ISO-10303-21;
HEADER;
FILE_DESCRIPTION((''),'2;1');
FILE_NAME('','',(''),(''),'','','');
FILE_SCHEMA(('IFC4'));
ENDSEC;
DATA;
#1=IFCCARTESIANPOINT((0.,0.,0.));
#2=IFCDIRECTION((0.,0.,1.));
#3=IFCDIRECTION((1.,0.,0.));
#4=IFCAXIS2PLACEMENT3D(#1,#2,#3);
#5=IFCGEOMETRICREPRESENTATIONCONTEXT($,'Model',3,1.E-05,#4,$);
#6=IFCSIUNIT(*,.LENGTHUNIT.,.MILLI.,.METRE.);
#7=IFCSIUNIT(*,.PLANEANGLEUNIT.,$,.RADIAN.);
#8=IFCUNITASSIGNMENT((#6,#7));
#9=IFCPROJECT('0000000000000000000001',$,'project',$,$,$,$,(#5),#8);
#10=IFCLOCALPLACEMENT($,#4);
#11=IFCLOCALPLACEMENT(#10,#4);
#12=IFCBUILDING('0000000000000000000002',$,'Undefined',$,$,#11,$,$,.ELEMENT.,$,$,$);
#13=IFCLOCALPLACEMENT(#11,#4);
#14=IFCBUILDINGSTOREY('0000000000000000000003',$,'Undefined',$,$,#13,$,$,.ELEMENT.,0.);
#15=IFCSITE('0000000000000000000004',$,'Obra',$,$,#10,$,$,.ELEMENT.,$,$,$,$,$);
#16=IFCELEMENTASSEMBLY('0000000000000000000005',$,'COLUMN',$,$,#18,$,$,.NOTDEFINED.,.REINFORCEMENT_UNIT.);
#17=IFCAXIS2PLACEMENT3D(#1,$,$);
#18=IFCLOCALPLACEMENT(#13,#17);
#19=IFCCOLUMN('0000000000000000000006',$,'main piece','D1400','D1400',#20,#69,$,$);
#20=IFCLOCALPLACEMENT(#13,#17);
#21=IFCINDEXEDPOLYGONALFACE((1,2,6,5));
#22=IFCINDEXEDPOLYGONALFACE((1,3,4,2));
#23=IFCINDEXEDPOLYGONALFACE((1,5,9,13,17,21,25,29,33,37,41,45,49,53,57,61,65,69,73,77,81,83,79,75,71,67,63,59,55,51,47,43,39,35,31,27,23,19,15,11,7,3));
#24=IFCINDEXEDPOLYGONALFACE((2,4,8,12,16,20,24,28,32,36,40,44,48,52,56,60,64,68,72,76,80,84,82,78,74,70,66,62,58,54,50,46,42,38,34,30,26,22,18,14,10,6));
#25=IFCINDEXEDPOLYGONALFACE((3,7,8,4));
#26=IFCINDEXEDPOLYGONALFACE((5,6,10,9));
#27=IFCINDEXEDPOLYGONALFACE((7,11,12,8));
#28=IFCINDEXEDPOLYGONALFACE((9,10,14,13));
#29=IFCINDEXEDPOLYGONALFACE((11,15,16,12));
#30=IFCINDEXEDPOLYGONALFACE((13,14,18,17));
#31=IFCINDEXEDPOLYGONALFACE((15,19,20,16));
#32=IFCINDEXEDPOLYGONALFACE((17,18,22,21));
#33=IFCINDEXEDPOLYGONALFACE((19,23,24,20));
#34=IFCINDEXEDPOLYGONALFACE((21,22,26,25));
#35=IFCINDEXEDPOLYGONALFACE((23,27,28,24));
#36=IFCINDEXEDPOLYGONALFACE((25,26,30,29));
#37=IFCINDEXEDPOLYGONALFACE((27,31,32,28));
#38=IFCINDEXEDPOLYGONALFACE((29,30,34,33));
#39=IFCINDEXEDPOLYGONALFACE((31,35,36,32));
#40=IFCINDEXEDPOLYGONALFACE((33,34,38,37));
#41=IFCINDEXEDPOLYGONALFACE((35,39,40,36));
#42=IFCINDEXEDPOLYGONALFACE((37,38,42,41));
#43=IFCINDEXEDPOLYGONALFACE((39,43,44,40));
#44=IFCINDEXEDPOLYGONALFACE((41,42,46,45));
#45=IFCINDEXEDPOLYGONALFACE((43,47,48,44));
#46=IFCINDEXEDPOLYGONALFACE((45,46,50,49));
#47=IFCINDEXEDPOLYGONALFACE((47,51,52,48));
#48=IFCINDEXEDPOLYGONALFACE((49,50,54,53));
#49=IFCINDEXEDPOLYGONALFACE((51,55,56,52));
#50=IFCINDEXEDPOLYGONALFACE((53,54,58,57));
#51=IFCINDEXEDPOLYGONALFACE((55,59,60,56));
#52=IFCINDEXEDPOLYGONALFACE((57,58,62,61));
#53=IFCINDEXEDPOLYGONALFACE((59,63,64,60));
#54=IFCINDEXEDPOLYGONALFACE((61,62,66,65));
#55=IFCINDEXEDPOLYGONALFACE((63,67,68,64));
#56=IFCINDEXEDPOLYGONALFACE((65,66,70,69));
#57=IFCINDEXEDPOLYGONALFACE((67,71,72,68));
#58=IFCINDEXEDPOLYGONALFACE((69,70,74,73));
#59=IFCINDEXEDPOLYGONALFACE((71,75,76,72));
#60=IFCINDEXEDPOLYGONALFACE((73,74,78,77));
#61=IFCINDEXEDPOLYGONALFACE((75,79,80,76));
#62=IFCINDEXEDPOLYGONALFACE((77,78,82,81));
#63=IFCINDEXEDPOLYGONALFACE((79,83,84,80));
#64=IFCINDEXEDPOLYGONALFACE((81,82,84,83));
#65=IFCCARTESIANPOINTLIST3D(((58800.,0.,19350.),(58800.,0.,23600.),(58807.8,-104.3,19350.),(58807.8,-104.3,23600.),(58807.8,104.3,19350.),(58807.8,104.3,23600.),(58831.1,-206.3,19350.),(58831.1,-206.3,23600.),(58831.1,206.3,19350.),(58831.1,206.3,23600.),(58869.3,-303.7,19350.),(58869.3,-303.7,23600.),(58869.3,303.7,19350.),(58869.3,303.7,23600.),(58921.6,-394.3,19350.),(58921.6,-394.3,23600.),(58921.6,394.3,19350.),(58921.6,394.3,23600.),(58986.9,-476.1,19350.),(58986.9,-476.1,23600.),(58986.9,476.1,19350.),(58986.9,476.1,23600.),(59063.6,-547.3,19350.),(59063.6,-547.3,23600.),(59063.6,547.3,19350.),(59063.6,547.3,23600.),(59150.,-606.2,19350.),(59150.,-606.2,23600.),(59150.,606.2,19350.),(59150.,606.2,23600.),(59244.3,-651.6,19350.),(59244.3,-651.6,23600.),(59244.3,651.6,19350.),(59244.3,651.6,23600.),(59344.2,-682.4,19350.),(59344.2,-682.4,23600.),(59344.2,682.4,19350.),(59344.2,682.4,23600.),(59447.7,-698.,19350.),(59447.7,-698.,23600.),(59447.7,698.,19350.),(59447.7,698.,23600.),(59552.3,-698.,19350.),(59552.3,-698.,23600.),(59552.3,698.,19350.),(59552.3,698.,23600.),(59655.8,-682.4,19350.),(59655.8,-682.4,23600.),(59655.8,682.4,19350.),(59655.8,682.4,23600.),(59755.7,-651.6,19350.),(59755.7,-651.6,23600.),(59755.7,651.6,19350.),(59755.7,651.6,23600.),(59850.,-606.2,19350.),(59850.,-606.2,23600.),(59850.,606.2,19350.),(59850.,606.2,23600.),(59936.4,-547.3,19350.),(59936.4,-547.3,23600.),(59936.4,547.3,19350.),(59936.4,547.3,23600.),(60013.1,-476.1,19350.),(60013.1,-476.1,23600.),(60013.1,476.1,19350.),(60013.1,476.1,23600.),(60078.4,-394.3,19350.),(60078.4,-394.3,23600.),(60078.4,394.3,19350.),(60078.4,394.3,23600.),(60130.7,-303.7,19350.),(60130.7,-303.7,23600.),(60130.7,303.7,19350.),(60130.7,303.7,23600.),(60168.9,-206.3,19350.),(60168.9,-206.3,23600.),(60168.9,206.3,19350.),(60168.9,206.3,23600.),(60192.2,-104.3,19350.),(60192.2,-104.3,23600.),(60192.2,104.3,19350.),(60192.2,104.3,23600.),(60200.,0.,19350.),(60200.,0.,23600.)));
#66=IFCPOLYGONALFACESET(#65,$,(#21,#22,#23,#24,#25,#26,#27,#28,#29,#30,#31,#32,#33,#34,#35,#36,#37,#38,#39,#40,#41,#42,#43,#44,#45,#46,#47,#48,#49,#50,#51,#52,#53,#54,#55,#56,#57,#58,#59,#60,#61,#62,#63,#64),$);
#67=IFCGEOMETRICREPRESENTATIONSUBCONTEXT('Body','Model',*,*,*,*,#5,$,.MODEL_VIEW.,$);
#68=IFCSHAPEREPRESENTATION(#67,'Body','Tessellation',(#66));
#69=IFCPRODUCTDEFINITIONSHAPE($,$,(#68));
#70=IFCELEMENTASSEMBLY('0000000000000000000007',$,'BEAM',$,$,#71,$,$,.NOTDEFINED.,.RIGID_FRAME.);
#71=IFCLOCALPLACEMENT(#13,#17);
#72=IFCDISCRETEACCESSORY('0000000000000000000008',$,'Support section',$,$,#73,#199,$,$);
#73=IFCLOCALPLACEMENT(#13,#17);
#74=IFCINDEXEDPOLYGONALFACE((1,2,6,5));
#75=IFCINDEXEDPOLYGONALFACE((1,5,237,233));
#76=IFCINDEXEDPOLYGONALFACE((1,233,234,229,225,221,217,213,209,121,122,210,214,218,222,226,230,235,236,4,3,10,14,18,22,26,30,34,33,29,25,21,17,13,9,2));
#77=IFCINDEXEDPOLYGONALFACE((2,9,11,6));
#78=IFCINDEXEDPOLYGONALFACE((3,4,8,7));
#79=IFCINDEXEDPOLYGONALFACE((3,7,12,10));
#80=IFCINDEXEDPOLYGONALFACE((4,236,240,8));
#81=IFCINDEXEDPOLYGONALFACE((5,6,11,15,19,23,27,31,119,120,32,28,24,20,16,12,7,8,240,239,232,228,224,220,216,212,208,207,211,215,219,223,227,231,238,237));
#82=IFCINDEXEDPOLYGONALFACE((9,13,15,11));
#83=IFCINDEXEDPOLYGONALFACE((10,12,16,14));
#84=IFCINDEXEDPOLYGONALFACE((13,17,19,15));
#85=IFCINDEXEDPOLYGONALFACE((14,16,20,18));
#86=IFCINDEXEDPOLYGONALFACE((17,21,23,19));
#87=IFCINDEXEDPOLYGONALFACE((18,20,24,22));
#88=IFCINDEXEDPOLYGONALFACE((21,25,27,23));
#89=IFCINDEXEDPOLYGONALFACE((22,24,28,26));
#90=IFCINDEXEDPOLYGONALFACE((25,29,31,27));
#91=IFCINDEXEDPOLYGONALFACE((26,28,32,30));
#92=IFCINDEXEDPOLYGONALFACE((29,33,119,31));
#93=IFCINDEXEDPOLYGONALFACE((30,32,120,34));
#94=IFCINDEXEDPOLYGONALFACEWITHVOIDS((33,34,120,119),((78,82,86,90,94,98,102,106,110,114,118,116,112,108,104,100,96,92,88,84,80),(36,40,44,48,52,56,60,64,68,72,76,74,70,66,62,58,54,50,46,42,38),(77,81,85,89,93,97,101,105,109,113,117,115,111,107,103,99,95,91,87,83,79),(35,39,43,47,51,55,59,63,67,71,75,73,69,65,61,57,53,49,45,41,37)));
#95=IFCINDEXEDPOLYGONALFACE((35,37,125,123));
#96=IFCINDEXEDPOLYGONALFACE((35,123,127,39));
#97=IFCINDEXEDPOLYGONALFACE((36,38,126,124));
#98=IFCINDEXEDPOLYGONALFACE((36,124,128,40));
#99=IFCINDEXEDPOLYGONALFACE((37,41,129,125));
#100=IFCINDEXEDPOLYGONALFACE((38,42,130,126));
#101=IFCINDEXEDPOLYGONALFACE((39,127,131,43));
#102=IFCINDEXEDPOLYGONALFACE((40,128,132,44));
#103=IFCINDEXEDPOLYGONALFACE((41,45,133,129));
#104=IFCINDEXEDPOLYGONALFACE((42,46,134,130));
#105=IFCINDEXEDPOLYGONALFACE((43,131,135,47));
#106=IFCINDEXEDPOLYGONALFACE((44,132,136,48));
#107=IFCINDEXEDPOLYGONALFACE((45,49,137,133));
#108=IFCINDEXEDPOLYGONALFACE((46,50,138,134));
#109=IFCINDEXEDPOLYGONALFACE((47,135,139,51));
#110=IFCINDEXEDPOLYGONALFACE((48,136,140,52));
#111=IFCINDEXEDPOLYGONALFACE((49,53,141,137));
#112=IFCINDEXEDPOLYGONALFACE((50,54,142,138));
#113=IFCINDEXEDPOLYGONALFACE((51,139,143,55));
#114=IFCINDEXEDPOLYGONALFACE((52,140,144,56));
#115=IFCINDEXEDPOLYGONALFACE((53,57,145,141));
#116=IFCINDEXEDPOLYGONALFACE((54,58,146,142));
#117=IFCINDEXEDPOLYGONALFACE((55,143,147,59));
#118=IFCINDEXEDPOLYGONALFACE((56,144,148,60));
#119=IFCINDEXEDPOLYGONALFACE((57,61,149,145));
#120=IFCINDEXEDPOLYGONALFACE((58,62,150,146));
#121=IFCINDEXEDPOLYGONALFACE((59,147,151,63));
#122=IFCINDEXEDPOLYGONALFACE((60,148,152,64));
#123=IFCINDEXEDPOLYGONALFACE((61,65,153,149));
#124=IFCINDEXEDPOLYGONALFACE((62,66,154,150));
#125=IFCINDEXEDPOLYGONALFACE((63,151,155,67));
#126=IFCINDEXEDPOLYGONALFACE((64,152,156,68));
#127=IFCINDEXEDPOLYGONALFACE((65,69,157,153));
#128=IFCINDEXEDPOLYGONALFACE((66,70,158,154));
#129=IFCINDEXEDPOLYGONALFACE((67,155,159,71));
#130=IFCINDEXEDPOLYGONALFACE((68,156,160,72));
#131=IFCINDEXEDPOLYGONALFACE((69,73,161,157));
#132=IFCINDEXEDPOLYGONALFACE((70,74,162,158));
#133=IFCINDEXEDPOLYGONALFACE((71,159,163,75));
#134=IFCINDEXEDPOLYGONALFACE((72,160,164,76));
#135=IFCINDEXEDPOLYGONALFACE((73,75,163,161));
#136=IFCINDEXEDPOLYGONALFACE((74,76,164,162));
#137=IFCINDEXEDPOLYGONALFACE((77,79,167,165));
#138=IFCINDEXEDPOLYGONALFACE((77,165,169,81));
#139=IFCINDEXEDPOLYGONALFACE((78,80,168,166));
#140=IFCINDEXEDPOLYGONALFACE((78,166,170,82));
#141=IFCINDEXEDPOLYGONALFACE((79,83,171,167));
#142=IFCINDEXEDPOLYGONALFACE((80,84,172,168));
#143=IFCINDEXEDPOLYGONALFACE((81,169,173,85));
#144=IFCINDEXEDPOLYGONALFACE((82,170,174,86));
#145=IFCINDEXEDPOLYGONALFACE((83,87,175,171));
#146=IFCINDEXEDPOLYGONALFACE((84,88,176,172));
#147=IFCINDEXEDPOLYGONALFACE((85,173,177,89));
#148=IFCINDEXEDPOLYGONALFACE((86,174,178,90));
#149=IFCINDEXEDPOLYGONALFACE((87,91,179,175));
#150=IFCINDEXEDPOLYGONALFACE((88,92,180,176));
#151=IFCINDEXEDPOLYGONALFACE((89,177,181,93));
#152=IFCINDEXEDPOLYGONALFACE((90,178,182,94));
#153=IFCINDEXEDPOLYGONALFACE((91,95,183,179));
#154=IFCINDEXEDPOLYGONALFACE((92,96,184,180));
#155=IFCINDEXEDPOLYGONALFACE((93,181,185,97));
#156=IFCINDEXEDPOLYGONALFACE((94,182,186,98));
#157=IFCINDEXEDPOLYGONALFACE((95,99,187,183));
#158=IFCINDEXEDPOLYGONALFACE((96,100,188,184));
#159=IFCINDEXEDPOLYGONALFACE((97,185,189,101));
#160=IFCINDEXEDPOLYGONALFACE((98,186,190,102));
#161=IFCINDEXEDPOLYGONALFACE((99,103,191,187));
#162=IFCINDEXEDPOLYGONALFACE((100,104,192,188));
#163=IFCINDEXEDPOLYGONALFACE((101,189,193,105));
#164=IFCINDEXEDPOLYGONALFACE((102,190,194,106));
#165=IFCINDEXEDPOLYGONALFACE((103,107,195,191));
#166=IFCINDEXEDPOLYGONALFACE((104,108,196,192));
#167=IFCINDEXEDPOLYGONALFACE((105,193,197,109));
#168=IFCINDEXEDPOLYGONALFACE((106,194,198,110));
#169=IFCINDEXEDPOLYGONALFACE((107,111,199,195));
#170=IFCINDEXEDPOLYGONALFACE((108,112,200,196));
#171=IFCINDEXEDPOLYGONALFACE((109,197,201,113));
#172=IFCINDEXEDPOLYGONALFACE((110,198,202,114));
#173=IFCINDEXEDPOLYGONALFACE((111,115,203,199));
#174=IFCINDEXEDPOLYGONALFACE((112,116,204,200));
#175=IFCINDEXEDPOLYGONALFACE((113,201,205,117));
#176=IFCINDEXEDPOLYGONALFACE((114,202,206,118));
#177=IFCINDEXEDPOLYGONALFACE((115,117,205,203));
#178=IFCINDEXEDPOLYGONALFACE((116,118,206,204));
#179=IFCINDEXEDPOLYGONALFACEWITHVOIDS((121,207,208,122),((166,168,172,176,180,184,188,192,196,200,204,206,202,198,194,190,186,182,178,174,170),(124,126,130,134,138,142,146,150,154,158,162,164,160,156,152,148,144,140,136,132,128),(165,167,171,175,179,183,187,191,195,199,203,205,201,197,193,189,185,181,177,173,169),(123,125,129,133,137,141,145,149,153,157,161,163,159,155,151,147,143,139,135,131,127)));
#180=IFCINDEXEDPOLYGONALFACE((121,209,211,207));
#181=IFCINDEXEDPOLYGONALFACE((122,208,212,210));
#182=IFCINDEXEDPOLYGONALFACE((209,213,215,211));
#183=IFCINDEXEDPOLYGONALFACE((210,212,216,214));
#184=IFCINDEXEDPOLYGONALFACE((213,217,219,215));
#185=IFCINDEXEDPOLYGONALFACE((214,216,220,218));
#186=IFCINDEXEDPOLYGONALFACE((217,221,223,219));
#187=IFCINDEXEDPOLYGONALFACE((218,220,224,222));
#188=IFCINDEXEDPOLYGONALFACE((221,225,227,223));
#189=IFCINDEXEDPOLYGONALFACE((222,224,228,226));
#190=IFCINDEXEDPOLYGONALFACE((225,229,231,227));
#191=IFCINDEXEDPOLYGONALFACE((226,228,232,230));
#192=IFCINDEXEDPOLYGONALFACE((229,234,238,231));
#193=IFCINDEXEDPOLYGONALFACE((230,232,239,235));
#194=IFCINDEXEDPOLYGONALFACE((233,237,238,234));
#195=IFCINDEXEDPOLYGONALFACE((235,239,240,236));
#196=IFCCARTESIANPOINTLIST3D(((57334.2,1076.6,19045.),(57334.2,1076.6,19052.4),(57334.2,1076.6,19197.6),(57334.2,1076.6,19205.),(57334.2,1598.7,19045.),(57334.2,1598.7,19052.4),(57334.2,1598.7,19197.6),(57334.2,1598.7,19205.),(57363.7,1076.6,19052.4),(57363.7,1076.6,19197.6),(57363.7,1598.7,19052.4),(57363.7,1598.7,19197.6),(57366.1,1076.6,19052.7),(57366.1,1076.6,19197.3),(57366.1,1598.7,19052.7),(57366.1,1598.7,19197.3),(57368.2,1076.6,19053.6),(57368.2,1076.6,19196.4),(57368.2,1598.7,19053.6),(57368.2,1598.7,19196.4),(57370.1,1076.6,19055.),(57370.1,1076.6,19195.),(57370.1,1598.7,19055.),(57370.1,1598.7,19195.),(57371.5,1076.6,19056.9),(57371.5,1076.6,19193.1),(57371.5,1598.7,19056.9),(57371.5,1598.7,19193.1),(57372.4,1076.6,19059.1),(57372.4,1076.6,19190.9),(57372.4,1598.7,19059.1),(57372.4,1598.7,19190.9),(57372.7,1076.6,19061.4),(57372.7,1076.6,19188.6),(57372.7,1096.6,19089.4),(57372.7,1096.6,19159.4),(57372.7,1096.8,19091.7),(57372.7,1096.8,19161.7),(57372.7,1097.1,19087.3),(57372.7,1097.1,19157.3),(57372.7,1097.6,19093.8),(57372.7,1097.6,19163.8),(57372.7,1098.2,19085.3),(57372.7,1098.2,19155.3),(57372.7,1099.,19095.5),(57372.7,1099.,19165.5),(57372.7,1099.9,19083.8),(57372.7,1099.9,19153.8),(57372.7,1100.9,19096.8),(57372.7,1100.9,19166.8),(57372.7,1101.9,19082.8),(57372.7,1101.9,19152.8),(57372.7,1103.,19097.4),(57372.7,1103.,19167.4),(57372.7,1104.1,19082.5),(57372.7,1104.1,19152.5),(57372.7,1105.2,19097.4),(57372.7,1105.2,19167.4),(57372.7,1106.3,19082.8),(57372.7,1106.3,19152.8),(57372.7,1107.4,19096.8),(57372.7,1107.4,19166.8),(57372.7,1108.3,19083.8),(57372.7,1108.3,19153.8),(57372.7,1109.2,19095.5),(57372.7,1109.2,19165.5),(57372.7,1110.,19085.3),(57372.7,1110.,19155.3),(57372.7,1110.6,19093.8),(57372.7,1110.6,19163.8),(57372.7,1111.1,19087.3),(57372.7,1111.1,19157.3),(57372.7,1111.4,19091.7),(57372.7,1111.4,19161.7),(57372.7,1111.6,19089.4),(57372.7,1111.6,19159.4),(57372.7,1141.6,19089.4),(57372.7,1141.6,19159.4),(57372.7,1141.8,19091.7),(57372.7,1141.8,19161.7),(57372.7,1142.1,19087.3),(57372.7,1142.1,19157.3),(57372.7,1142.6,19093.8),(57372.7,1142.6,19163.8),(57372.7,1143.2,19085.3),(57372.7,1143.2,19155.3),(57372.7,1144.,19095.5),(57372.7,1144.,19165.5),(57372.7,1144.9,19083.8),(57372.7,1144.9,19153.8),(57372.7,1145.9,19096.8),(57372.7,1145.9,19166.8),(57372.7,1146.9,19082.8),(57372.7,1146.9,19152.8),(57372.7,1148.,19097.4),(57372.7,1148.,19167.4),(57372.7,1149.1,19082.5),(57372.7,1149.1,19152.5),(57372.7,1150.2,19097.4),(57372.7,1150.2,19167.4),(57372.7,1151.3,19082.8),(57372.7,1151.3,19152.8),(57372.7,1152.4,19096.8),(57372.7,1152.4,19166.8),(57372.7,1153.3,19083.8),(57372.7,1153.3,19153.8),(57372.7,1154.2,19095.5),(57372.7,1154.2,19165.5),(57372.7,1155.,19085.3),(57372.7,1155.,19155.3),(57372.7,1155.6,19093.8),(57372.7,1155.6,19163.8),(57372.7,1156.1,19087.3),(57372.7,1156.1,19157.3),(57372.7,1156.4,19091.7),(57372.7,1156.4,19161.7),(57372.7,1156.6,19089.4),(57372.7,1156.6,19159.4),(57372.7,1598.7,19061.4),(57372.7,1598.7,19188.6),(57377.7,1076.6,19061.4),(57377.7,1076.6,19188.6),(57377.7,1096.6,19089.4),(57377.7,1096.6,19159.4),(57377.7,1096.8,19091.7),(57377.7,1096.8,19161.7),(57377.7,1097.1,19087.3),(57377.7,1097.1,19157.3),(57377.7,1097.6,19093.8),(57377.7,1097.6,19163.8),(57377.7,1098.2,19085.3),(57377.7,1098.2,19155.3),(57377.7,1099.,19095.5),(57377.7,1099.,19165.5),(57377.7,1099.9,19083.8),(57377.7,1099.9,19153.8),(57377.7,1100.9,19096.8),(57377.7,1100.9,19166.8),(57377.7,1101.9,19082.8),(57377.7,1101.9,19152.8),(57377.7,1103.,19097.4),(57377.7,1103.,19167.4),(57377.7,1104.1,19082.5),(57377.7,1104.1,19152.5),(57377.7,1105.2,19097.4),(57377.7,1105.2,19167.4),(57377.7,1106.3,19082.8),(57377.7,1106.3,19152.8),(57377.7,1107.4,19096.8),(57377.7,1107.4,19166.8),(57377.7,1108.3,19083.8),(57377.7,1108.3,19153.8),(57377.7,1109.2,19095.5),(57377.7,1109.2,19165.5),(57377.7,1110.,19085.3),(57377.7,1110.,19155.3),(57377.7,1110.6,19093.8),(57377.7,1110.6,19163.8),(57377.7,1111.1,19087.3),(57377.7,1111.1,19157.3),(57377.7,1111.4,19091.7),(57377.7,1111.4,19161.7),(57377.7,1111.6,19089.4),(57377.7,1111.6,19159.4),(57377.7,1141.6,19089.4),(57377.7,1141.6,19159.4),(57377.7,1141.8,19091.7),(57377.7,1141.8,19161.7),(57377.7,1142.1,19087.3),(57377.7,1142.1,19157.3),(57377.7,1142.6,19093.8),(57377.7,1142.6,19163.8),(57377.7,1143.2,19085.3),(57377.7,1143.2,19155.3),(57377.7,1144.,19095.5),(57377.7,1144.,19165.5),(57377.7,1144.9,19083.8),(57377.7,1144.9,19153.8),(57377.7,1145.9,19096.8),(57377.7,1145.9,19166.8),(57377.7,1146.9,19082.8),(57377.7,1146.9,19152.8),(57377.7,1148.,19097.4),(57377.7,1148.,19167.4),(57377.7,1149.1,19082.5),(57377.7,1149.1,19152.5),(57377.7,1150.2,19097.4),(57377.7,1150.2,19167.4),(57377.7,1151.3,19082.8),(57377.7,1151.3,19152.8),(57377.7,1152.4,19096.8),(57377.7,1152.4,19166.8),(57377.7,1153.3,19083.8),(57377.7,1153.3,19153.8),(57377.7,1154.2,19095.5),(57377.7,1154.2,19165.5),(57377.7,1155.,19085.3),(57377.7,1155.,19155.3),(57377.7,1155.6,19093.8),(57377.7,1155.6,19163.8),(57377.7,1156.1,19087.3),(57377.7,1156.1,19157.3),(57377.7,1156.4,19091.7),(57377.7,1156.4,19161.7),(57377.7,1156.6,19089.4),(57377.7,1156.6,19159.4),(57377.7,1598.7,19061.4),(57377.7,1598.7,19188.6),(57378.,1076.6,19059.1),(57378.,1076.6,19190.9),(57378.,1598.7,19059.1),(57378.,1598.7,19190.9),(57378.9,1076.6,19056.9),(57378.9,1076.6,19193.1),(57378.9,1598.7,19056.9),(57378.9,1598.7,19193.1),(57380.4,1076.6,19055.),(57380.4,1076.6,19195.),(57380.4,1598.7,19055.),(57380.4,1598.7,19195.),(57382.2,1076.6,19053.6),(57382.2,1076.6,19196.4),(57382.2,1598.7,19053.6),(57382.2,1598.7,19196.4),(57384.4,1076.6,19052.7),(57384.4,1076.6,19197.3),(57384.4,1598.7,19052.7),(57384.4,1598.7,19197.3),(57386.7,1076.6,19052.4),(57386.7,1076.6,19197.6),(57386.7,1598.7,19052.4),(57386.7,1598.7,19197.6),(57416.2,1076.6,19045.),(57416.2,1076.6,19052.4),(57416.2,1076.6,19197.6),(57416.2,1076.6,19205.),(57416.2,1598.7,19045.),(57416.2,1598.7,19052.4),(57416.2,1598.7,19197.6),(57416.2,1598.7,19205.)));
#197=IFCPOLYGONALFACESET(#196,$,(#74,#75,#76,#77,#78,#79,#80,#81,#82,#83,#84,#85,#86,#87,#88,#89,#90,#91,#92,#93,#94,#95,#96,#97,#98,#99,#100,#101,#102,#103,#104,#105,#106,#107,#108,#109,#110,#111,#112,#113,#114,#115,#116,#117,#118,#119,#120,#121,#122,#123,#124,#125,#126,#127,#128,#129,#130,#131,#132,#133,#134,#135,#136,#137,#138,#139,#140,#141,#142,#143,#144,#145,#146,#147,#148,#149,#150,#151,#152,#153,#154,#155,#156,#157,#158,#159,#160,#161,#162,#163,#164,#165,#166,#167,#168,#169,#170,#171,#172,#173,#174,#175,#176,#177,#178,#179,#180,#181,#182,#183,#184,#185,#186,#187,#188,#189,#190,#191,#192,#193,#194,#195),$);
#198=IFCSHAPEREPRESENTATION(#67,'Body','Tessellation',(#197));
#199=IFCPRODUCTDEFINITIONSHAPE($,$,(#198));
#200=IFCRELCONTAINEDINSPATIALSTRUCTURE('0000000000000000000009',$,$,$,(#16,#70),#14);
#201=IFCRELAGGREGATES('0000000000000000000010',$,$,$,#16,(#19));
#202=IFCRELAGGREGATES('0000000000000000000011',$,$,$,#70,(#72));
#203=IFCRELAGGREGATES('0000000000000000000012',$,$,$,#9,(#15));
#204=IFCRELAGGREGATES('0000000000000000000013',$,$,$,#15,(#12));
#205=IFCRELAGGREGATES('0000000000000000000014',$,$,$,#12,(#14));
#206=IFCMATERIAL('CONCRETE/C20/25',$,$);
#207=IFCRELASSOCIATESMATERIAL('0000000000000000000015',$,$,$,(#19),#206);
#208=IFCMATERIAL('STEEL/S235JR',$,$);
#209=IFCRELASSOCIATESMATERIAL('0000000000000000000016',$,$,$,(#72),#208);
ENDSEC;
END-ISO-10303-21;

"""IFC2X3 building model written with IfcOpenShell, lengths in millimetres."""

from ifc_helpers import new_model, si_unit, frame, origin_with_axes, origin_2d_with_axis, place, context, subcontext, project, spatial, circle, i_section, extrude, clip, halfspace, source, transform, mapped, material, element, aggregate, save


model = new_model("IFC2X3")

# Units and contexts
model_context = context("Model", 3, precision=1e-05, world=origin_with_axes())
body_context = subcontext(model_context, "Body", "Model", "MODEL_VIEW")
ifc_project = project(units=[si_unit("LENGTHUNIT", "METRE", prefix="MILLI"), si_unit("PLANEANGLEUNIT", "RADIAN")], contexts=[model_context])

# Site, building, storey
site_placement = place(None, origin_with_axes())
site = spatial("IfcSite", under=ifc_project, at=site_placement, Name="Obra", CompositionType="ELEMENT")
building_placement = place(site_placement, origin_with_axes())
building = spatial("IfcBuilding", under=site, at=building_placement, Name="Undefined", CompositionType="ELEMENT")
storey_placement = place(building_placement, origin_with_axes())
storey = spatial("IfcBuildingStorey", under=building, at=storey_placement, Name="Undefined", CompositionType="ELEMENT", Elevation=0.0)

# Element assembly, column
assembly_1_placement = place(storey_placement, origin_with_axes())
assembly_1 = element("IfcElementAssembly", 1, at=assembly_1_placement, inside=storey, Name="COLUMN", AssemblyPlace="NOTDEFINED", PredefinedType="REINFORCEMENT_UNIT")
ifc_material_1 = material(Name="CONCRETE/C20/25")
column_placement = place(assembly_1_placement, frame((59500.0, 0.0, 19350.0), z_axis=(0.0, 0.0, 1.0), x_axis=(0.0, 1.0, 0.0)))
column = element("IfcColumn", 2, at=column_placement, material=ifc_material_1, Name="main piece", Description="D1400", ObjectType="D1400", context=body_context, shape_type="SweptSolid", body=[
    extrude(circle(Radius=700.0, at=origin_2d_with_axis()), frame((0.0, 0.0, 4250.0), z_axis=(0.0, 0.0, -1.0), x_axis=(0.0, 1.0, 0.0)), (0.0, 0.0, 1.0), 4250.0),
])
aggregate(assembly_1, [column])

# Element assembly
ifc_material_2 = material(Name="STEEL/S235JR")
assembly_2_placement = place(storey_placement, origin_with_axes())
assembly_2 = element("IfcElementAssembly", 3, at=assembly_2_placement, inside=storey, Name="BEAM", AssemblyPlace="NOTDEFINED", PredefinedType="RIGID_FRAME")

# Discrete accessory, opening
discrete_accessory_1_placement = place(assembly_2_placement, frame((57375.2, 1086.6, 19125.0), z_axis=(0.0, 0.0, 1.0), x_axis=(0.0, 1.0, 0.0)))
discrete_accessory_1 = element("IfcDiscreteAccessory", 4, at=discrete_accessory_1_placement, material=ifc_material_2, Name="Support section", context=body_context, shape_type="Clipping", body=[
    clip(clip(extrude(i_section(OverallWidth=82.0, OverallDepth=160.0, WebThickness=5.0, FlangeThickness=7.4, FilletRadius=9.0, at=origin_2d_with_axis()), frame((512.1, 0.0, 0.0), z_axis=(-1.0, 0.0, 0.0), x_axis=(0.0, -1.0, 0.0)), (0.0, 0.0, 1.0), 522.1), halfspace(frame((512.1, 0.0, 580.0), z_axis=(1.0, 0.0, 0.0), x_axis=(0.0, 1.0, 0.0)), False)), halfspace(frame((-10.0, 0.0, -180.0), z_axis=(1.0, 0.0, 0.0), x_axis=(0.0, -1.0, 0.0)), True)),
])
shared_shape_1 = source(origin_with_axes(), body_context, "Body", "SweptSolid", [
    extrude(circle(Radius=7.5, at=origin_2d_with_axis()), frame((0.0, -2.6, 0.0), z_axis=(0.0, 1.0, 0.0), x_axis=(1.0, 0.0, 0.0)), (0.0, 0.0, 1.0), 5.2),
])
opening_1_placement = place(assembly_2_placement, frame((57375.2, 1126.6, 19160.0), z_axis=(0.0, 1.0, 0.0), x_axis=(0.0, 0.0, -1.0)))
element("IfcOpeningElement", 5, at=opening_1_placement, cuts=discrete_accessory_1, ObjectType="Opening", context=body_context, shape_type="MappedRepresentation", body=[
    mapped(shared_shape_1, transform((0.0, 0.0, -22.5))),
    mapped(shared_shape_1, transform((70.0, 0.0, -22.5))),
    mapped(shared_shape_1, transform((0.0, 0.0, 22.5))),
    mapped(shared_shape_1, transform((70.0, 0.0, 22.5))),
])

aggregate(assembly_2, [discrete_accessory_1])

save(model, "model.ifc")
